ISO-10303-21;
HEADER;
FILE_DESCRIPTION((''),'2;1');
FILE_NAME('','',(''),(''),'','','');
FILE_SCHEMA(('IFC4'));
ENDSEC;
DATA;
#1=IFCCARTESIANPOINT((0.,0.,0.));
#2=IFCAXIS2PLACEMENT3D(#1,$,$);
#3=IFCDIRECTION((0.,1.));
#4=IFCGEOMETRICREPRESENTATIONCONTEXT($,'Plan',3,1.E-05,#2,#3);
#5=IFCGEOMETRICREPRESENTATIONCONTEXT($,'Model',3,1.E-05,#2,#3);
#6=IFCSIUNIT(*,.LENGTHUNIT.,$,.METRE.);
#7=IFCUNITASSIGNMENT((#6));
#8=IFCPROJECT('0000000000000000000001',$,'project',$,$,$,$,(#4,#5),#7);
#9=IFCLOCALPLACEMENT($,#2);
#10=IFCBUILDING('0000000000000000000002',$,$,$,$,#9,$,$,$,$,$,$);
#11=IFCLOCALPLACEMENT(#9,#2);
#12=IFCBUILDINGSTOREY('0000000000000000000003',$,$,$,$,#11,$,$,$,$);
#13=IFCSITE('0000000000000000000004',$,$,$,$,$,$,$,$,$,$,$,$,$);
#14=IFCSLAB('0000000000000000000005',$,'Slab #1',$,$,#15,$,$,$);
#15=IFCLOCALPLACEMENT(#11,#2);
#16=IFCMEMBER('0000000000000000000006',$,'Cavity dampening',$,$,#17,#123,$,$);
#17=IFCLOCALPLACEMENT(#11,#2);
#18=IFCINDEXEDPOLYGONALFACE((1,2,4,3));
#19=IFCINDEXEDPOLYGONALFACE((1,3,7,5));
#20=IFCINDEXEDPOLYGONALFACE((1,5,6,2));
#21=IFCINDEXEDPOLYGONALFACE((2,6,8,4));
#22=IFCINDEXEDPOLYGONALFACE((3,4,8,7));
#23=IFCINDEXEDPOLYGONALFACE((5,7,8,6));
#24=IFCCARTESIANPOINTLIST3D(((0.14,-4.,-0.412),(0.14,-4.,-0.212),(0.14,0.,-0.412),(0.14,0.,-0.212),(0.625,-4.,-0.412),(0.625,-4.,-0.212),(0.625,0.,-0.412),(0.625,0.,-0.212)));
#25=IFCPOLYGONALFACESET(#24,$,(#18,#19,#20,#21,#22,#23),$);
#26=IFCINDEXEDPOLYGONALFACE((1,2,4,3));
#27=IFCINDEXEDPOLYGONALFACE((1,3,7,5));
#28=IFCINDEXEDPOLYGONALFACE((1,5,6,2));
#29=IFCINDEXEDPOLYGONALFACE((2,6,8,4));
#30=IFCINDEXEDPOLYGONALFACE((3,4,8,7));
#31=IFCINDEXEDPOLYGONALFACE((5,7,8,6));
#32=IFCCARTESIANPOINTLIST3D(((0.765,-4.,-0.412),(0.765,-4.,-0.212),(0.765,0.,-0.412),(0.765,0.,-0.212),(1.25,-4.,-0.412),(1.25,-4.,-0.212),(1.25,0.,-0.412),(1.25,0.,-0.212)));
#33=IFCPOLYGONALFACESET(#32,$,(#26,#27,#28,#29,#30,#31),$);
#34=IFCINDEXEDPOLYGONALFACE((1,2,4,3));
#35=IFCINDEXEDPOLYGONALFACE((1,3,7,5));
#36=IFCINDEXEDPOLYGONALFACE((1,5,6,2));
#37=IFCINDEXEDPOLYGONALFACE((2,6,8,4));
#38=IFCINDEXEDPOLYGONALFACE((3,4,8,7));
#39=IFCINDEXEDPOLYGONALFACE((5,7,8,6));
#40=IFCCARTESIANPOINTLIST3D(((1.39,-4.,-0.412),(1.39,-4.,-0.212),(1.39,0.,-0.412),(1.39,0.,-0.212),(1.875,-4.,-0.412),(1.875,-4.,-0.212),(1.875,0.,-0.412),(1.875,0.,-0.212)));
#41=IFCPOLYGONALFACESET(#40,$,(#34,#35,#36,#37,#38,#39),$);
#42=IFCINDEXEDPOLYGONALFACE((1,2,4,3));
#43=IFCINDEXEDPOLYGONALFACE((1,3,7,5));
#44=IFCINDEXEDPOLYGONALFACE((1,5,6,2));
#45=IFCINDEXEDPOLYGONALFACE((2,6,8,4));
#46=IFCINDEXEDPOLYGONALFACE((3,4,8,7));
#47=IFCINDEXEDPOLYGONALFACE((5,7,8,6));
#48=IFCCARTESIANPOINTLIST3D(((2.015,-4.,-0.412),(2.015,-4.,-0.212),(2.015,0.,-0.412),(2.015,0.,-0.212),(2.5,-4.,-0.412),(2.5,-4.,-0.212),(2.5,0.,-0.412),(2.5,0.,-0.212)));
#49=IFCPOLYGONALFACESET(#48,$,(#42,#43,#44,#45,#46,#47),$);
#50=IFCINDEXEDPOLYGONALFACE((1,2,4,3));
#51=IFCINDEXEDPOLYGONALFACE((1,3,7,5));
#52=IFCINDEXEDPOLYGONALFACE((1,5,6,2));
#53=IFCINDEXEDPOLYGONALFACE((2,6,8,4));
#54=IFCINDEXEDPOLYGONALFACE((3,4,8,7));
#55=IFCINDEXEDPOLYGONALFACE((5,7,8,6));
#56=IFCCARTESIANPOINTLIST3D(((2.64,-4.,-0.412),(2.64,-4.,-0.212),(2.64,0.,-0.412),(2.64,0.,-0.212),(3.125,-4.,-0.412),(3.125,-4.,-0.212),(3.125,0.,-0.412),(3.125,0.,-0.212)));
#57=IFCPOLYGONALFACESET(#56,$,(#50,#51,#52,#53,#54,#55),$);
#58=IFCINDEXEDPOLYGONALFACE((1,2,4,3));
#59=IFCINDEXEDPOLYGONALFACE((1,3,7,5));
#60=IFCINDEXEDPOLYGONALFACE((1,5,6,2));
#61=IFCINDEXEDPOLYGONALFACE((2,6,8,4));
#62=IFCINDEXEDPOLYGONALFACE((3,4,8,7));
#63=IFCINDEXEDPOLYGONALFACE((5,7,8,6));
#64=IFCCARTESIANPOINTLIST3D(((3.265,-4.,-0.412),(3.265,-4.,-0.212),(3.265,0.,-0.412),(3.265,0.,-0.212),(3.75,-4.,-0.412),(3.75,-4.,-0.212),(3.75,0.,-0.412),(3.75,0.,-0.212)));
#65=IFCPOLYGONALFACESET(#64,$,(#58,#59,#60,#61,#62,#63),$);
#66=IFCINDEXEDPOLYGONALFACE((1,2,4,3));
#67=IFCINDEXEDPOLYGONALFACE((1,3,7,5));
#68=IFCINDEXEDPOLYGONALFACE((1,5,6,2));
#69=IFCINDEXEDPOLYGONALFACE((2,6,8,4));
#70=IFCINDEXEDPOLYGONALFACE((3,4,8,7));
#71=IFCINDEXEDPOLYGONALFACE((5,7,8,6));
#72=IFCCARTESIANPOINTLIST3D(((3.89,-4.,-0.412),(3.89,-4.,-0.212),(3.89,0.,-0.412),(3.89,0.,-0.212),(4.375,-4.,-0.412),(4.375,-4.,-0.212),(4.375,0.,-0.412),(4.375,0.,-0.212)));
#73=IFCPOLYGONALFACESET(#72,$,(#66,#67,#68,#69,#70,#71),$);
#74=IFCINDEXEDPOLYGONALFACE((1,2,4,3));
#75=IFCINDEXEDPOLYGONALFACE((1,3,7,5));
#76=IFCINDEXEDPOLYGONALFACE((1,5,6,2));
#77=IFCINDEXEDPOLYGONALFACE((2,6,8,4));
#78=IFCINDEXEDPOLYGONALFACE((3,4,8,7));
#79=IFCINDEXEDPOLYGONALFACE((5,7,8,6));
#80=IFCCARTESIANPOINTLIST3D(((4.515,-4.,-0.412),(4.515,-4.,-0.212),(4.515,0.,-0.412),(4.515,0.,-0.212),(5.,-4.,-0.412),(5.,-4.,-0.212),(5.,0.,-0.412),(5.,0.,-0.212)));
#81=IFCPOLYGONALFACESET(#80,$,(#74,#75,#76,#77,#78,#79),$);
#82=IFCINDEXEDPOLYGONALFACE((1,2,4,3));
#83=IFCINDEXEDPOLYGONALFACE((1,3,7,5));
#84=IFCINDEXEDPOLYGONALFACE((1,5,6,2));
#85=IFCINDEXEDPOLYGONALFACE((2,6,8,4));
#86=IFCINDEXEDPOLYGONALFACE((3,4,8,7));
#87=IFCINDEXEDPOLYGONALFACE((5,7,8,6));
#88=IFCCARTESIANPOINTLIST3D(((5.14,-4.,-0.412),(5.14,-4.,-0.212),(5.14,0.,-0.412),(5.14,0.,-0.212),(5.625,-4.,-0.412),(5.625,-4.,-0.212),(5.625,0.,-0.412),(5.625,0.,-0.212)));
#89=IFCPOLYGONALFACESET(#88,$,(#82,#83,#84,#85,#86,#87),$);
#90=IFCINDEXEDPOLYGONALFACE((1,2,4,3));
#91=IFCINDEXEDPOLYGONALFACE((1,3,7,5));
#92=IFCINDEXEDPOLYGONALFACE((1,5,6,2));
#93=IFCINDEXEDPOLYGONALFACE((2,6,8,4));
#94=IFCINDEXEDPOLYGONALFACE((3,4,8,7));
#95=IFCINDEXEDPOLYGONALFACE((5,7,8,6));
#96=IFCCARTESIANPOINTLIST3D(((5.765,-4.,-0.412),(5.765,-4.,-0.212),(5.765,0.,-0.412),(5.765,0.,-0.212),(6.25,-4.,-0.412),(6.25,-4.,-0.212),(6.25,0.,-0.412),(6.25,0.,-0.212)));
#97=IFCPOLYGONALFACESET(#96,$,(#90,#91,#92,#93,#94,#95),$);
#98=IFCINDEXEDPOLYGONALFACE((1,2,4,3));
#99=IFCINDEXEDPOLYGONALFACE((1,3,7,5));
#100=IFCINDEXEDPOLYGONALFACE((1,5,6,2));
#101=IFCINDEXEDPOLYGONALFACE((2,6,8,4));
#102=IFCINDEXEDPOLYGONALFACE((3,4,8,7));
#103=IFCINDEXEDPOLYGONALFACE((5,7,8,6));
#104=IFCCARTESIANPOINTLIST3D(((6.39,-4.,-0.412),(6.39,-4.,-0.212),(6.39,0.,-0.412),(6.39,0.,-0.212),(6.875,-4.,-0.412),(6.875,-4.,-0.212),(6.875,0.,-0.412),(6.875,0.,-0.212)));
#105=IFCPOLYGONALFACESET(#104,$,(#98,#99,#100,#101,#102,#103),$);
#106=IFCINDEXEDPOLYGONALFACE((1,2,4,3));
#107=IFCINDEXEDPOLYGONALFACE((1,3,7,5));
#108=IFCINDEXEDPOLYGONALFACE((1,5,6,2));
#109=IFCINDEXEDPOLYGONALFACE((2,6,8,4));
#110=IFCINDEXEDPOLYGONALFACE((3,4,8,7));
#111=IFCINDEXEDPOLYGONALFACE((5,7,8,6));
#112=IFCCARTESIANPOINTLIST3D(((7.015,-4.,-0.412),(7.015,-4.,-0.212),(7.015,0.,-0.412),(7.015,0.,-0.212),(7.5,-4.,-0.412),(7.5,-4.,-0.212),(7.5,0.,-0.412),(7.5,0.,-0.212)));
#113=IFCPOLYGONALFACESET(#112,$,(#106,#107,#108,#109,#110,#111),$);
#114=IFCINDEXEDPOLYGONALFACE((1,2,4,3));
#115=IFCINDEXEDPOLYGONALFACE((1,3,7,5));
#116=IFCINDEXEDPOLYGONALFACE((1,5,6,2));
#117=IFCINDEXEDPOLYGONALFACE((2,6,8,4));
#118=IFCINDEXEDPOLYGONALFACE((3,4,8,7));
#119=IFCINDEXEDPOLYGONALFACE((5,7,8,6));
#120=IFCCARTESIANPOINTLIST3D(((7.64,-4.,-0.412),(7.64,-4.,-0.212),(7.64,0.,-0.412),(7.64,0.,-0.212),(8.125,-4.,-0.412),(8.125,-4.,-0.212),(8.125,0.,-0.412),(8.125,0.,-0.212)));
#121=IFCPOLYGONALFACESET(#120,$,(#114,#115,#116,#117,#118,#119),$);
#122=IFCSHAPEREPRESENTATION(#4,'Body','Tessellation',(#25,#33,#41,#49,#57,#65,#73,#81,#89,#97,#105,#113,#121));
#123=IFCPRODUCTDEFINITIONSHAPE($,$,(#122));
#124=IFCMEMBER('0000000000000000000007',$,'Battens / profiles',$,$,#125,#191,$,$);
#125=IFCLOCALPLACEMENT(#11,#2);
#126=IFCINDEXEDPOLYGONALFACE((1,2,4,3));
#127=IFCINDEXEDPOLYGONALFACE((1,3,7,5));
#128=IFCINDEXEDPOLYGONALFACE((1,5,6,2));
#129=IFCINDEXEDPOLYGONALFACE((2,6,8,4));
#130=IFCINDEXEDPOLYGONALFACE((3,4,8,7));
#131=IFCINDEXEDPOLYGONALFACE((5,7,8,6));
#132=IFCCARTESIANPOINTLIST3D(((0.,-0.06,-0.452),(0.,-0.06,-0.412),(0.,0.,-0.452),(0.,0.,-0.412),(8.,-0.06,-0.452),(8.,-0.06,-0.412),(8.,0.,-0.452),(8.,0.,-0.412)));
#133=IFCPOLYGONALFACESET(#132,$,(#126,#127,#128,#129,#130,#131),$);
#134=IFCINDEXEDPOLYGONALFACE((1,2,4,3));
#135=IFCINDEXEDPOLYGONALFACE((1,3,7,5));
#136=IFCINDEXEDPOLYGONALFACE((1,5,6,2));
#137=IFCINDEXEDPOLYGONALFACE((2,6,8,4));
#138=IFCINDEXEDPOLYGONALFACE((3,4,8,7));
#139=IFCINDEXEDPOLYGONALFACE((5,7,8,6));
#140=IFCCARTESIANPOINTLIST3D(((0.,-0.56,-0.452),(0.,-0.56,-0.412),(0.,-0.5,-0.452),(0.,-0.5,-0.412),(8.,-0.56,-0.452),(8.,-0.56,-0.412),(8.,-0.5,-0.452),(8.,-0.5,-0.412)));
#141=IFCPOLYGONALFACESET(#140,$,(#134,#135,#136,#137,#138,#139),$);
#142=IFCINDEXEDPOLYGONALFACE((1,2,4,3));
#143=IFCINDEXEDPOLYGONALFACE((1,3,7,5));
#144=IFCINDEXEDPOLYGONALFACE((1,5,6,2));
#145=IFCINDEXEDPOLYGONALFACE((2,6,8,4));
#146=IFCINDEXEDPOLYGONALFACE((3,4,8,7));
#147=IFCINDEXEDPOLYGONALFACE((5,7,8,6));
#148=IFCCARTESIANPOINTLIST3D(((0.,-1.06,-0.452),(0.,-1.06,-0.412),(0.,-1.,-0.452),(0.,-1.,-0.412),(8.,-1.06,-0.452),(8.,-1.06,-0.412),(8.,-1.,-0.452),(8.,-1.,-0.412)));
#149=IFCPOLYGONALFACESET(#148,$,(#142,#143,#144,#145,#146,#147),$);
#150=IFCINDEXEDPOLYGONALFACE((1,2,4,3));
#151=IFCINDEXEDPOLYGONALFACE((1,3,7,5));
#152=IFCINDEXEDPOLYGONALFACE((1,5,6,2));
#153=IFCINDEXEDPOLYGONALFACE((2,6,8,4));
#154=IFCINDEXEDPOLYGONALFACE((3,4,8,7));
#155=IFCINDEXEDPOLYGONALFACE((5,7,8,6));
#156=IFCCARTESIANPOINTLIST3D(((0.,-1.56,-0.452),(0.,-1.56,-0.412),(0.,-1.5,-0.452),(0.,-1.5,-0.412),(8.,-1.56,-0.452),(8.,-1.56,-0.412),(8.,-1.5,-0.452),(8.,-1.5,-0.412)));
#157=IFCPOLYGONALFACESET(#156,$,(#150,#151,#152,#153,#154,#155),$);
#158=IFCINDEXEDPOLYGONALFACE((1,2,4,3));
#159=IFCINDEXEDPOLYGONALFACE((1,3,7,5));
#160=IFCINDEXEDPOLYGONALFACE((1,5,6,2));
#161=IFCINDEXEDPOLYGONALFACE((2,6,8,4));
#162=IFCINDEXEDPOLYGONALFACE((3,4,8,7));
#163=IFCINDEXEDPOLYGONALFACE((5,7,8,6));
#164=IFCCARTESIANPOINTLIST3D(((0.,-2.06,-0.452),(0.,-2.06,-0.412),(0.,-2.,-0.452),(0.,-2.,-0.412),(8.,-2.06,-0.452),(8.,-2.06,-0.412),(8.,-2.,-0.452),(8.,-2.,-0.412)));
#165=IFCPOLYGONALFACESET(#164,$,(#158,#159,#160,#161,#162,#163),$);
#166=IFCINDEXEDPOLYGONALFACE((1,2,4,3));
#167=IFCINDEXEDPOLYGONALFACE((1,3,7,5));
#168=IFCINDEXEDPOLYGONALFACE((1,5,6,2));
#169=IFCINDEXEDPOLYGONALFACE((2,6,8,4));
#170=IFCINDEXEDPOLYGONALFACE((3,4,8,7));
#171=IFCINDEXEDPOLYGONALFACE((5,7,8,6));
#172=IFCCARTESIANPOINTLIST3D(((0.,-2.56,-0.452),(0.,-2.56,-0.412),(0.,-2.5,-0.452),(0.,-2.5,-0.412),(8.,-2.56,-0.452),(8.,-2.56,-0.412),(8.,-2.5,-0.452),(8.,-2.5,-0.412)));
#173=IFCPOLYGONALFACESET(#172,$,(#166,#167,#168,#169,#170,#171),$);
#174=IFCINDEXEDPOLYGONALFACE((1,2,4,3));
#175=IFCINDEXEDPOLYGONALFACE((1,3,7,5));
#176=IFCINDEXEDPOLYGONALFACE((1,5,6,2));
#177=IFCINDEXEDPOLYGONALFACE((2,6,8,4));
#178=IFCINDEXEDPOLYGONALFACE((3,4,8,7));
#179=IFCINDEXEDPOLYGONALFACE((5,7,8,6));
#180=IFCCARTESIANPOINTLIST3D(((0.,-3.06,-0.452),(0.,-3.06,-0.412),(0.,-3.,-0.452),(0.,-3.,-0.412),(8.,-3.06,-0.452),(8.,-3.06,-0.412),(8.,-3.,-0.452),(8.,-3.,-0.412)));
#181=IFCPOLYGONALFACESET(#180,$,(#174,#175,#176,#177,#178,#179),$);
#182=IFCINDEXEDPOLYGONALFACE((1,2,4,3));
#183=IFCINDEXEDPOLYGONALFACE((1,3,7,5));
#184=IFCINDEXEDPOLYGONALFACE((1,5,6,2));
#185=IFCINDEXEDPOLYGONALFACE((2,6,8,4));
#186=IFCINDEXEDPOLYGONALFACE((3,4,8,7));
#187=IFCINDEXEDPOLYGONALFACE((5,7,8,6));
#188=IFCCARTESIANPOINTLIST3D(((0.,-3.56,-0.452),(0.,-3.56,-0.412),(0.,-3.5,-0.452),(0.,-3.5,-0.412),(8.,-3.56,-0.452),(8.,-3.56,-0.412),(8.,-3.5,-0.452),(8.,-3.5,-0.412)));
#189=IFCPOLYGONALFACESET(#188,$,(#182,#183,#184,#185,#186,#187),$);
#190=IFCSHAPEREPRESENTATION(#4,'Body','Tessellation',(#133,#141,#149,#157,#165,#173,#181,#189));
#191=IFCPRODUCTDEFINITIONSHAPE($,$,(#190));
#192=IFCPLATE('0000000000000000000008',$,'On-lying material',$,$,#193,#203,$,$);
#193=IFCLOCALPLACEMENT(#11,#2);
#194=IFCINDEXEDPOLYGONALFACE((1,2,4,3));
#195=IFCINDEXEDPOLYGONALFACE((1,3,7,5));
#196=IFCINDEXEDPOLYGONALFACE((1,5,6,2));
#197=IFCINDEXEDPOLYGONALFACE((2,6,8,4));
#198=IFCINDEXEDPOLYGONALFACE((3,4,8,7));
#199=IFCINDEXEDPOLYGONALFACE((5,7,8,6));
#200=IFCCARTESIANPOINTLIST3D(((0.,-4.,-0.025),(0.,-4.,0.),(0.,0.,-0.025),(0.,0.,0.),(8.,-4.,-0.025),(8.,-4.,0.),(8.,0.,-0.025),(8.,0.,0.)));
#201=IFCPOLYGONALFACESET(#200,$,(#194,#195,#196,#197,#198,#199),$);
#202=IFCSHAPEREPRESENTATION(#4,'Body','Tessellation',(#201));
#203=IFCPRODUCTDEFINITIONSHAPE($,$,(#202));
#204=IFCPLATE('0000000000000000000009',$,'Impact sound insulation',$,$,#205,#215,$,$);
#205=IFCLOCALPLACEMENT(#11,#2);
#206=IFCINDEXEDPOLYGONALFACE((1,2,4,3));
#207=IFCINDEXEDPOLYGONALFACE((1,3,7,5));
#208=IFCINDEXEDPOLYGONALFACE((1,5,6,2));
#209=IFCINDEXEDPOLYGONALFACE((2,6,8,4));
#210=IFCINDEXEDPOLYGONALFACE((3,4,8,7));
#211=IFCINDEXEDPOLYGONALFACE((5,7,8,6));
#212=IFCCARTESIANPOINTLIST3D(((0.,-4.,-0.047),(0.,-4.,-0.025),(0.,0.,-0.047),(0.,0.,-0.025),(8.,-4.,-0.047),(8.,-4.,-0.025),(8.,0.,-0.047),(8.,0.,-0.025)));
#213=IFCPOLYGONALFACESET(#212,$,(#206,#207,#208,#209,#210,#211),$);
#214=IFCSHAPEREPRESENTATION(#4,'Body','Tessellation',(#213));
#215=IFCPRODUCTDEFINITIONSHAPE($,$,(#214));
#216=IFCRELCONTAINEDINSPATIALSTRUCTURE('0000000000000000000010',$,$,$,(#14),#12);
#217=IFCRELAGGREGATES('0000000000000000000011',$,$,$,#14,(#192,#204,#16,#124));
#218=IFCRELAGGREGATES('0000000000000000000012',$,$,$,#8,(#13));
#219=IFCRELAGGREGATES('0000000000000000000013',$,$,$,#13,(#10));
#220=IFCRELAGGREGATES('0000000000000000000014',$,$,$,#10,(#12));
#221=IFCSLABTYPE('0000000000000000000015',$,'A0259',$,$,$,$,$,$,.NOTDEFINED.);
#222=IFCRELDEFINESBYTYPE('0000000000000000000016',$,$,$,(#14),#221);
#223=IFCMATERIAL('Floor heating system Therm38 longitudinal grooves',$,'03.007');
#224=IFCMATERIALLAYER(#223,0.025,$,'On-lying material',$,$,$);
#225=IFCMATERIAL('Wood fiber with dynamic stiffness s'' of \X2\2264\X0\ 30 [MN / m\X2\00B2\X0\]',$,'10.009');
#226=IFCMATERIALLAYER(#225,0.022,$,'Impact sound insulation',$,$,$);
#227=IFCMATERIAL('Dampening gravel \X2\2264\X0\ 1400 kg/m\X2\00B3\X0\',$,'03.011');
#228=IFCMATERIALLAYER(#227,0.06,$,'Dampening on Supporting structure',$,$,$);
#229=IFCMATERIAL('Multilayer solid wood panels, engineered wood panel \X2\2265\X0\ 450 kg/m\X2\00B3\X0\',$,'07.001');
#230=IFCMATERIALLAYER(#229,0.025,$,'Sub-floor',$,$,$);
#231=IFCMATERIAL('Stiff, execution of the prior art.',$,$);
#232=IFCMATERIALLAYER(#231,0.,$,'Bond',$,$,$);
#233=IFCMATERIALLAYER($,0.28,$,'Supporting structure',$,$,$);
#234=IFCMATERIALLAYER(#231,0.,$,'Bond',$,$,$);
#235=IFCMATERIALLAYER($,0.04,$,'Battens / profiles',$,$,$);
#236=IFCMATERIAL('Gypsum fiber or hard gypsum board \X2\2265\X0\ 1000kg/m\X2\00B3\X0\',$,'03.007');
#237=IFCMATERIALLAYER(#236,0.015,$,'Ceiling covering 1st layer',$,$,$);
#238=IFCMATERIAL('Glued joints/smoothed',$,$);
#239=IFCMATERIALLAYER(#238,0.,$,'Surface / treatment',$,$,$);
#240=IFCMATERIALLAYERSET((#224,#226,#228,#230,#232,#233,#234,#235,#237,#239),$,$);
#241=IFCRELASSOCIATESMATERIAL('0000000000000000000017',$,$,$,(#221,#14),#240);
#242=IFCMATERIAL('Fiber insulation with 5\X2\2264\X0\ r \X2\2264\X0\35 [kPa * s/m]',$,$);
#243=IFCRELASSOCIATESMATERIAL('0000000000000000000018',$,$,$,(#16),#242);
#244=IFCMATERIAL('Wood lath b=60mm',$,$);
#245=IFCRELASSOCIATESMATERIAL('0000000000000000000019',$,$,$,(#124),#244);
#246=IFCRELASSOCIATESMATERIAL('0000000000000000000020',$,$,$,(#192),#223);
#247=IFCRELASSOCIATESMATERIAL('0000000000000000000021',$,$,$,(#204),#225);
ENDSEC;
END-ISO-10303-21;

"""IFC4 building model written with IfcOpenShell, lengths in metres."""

from ifc_helpers import new_model, si_unit, direction, frame, frame_2d, origin, origin_with_axes, place, context, project, spatial, rectangle, extrude, material, layer, layer_set, type_object, element, aggregate, save


model = new_model("IFC4")

# Units and contexts
plan_context = context("Plan", 3, precision=1e-05, world=origin(), true_north=direction((0.0, 1.0)))
model_context = context("Model", 3, precision=1e-05, world=origin(), true_north=direction((0.0, 1.0)))
ifc_project = project(units=[si_unit("LENGTHUNIT", "METRE")], contexts=[plan_context, model_context])

# Site, building, storey
site = spatial("IfcSite", under=ifc_project)
building_placement = place(None, origin())
building = spatial("IfcBuilding", under=site, at=building_placement)
storey_placement = place(building_placement, origin())
storey = spatial("IfcBuildingStorey", under=building, at=storey_placement)

# Slab, members, plates
ifc_material_1 = material(Name="Floor heating system Therm38 longitudinal grooves", Category="03.007")
ifc_layer_1 = layer(ifc_material_1, 0.025, Name="On-lying material")
ifc_material_2 = material(Name="Wood fiber with dynamic stiffness s' of ≤ 30 [MN / m²]", Category="10.009")
ifc_layer_2 = layer(ifc_material_2, 0.022, Name="Impact sound insulation")
ifc_material_3 = material(Name="Dampening gravel ≤ 1400 kg/m³", Category="03.011")
ifc_layer_3 = layer(ifc_material_3, 0.06, Name="Dampening on Supporting structure")
ifc_material_4 = material(Name="Multilayer solid wood panels, engineered wood panel ≥ 450 kg/m³", Category="07.001")
ifc_layer_4 = layer(ifc_material_4, 0.025, Name="Sub-floor")
ifc_material_5 = material(Name="Stiff, execution of the prior art.")
ifc_layer_5 = layer(ifc_material_5, 0.0, Name="Bond")
ifc_layer_6 = layer(None, 0.28, Name="Supporting structure")
ifc_layer_7 = layer(ifc_material_5, 0.0, Name="Bond")
ifc_layer_8 = layer(None, 0.04, Name="Battens / profiles")
ifc_material_6 = material(Name="Gypsum fiber or hard gypsum board ≥ 1000kg/m³", Category="03.007")
ifc_layer_9 = layer(ifc_material_6, 0.015, Name="Ceiling covering 1st layer")
ifc_material_7 = material(Name="Glued joints/smoothed")
ifc_layer_10 = layer(ifc_material_7, 0.0, Name="Surface / treatment")
ifc_layer_set = layer_set([ifc_layer_1, ifc_layer_2, ifc_layer_3, ifc_layer_4, ifc_layer_5, ifc_layer_6, ifc_layer_7, ifc_layer_8, ifc_layer_9, ifc_layer_10])
slab_type = type_object("IfcSlabType", Name="A0259", PredefinedType="NOTDEFINED", material=ifc_layer_set)
slab_placement = place(None, frame((0.0, 0.0, 0.0), z_axis=(0.0, 0.0, -1.0), x_axis=(1.0, 0.0, 0.0)))
slab = element("IfcSlab", 1, at=slab_placement, inside=storey, type_object=slab_type, material=ifc_layer_set, Name="Slab #1")
ifc_material_8 = material(Name="Fiber insulation with 5≤ r ≤35 [kPa * s/m]")
member_1_placement = place(slab_placement, origin())
member_1 = element("IfcMember", 2, at=member_1_placement, material=ifc_material_8, Name="Cavity dampening", context=plan_context, shape_type="SweptSolid", body=[
    extrude(rectangle(XDim=0.485, YDim=0.2, at=frame_2d((0.2425, 0.1), x_axis=(1.0, 0.0))), frame((0.14, 4.0, 0.212), z_axis=(0.0, -1.0, 0.0), x_axis=(1.0, 0.0, 0.0)), (0.0, 0.0, 1.0), 4.0),
    extrude(rectangle(XDim=0.485, YDim=0.2, at=frame_2d((0.2425, 0.1), x_axis=(1.0, 0.0))), frame((0.765, 4.0, 0.212), z_axis=(0.0, -1.0, 0.0), x_axis=(1.0, 0.0, 0.0)), (0.0, 0.0, 1.0), 4.0),
    extrude(rectangle(XDim=0.485, YDim=0.2, at=frame_2d((0.2425, 0.1), x_axis=(1.0, 0.0))), frame((1.39, 4.0, 0.212), z_axis=(0.0, -1.0, 0.0), x_axis=(1.0, 0.0, 0.0)), (0.0, 0.0, 1.0), 4.0),
    extrude(rectangle(XDim=0.485, YDim=0.2, at=frame_2d((0.2425, 0.1), x_axis=(1.0, 0.0))), frame((2.015, 4.0, 0.212), z_axis=(0.0, -1.0, 0.0), x_axis=(1.0, 0.0, 0.0)), (0.0, 0.0, 1.0), 4.0),
    extrude(rectangle(XDim=0.485, YDim=0.2, at=frame_2d((0.2425, 0.1), x_axis=(1.0, 0.0))), frame((2.64, 4.0, 0.212), z_axis=(0.0, -1.0, 0.0), x_axis=(1.0, 0.0, 0.0)), (0.0, 0.0, 1.0), 4.0),
    extrude(rectangle(XDim=0.485, YDim=0.2, at=frame_2d((0.2425, 0.1), x_axis=(1.0, 0.0))), frame((3.265, 4.0, 0.212), z_axis=(0.0, -1.0, 0.0), x_axis=(1.0, 0.0, 0.0)), (0.0, 0.0, 1.0), 4.0),
    extrude(rectangle(XDim=0.485, YDim=0.2, at=frame_2d((0.2425, 0.1), x_axis=(1.0, 0.0))), frame((3.89, 4.0, 0.212), z_axis=(0.0, -1.0, 0.0), x_axis=(1.0, 0.0, 0.0)), (0.0, 0.0, 1.0), 4.0),
    extrude(rectangle(XDim=0.485, YDim=0.2, at=frame_2d((0.2425, 0.1), x_axis=(1.0, 0.0))), frame((4.515, 4.0, 0.212), z_axis=(0.0, -1.0, 0.0), x_axis=(1.0, 0.0, 0.0)), (0.0, 0.0, 1.0), 4.0),
    extrude(rectangle(XDim=0.485, YDim=0.2, at=frame_2d((0.2425, 0.1), x_axis=(1.0, 0.0))), frame((5.14, 4.0, 0.212), z_axis=(0.0, -1.0, 0.0), x_axis=(1.0, 0.0, 0.0)), (0.0, 0.0, 1.0), 4.0),
    extrude(rectangle(XDim=0.485, YDim=0.2, at=frame_2d((0.2425, 0.1), x_axis=(1.0, 0.0))), frame((5.765, 4.0, 0.212), z_axis=(0.0, -1.0, 0.0), x_axis=(1.0, 0.0, 0.0)), (0.0, 0.0, 1.0), 4.0),
    extrude(rectangle(XDim=0.485, YDim=0.2, at=frame_2d((0.2425, 0.1), x_axis=(1.0, 0.0))), frame((6.39, 4.0, 0.212), z_axis=(0.0, -1.0, 0.0), x_axis=(1.0, 0.0, 0.0)), (0.0, 0.0, 1.0), 4.0),
    extrude(rectangle(XDim=0.485, YDim=0.2, at=frame_2d((0.2425, 0.1), x_axis=(1.0, 0.0))), frame((7.015, 4.0, 0.212), z_axis=(0.0, -1.0, 0.0), x_axis=(1.0, 0.0, 0.0)), (0.0, 0.0, 1.0), 4.0),
    extrude(rectangle(XDim=0.485, YDim=0.2, at=frame_2d((0.2425, 0.1), x_axis=(1.0, 0.0))), frame((7.64, 4.0, 0.212), z_axis=(0.0, -1.0, 0.0), x_axis=(1.0, 0.0, 0.0)), (0.0, 0.0, 1.0), 4.0),
])
ifc_material_9 = material(Name="Wood lath b=60mm")
member_2_placement = place(slab_placement, origin())
member_2 = element("IfcMember", 3, at=member_2_placement, material=ifc_material_9, Name="Battens / profiles", context=plan_context, shape_type="SweptSolid", body=[
    extrude(rectangle(XDim=0.06, YDim=0.04, at=frame_2d((0.03, 0.02), x_axis=(1.0, 0.0))), frame((0.0, 0.0, 0.412), z_axis=(1.0, 0.0, 0.0), x_axis=(0.0, 1.0, 0.0)), (0.0, 0.0, 1.0), 8.0),
    extrude(rectangle(XDim=0.06, YDim=0.04, at=frame_2d((0.03, 0.02), x_axis=(1.0, 0.0))), frame((0.0, 0.5, 0.412), z_axis=(1.0, 0.0, 0.0), x_axis=(0.0, 1.0, 0.0)), (0.0, 0.0, 1.0), 8.0),
    extrude(rectangle(XDim=0.06, YDim=0.04, at=frame_2d((0.03, 0.02), x_axis=(1.0, 0.0))), frame((0.0, 1.0, 0.412), z_axis=(1.0, 0.0, 0.0), x_axis=(0.0, 1.0, 0.0)), (0.0, 0.0, 1.0), 8.0),
    extrude(rectangle(XDim=0.06, YDim=0.04, at=frame_2d((0.03, 0.02), x_axis=(1.0, 0.0))), frame((0.0, 1.5, 0.412), z_axis=(1.0, 0.0, 0.0), x_axis=(0.0, 1.0, 0.0)), (0.0, 0.0, 1.0), 8.0),
    extrude(rectangle(XDim=0.06, YDim=0.04, at=frame_2d((0.03, 0.02), x_axis=(1.0, 0.0))), frame((0.0, 2.0, 0.412), z_axis=(1.0, 0.0, 0.0), x_axis=(0.0, 1.0, 0.0)), (0.0, 0.0, 1.0), 8.0),
    extrude(rectangle(XDim=0.06, YDim=0.04, at=frame_2d((0.03, 0.02), x_axis=(1.0, 0.0))), frame((0.0, 2.5, 0.412), z_axis=(1.0, 0.0, 0.0), x_axis=(0.0, 1.0, 0.0)), (0.0, 0.0, 1.0), 8.0),
    extrude(rectangle(XDim=0.06, YDim=0.04, at=frame_2d((0.03, 0.02), x_axis=(1.0, 0.0))), frame((0.0, 3.0, 0.412), z_axis=(1.0, 0.0, 0.0), x_axis=(0.0, 1.0, 0.0)), (0.0, 0.0, 1.0), 8.0),
    extrude(rectangle(XDim=0.06, YDim=0.04, at=frame_2d((0.03, 0.02), x_axis=(1.0, 0.0))), frame((0.0, 3.5, 0.412), z_axis=(1.0, 0.0, 0.0), x_axis=(0.0, 1.0, 0.0)), (0.0, 0.0, 1.0), 8.0),
])
plate_1_placement = place(slab_placement, origin())
plate_1 = element("IfcPlate", 4, at=plate_1_placement, material=ifc_material_1, Name="On-lying material", context=plan_context, shape_type="SweptSolid", body=[
    extrude(rectangle(XDim=8.0, YDim=4.0, at=frame_2d((4.0, 2.0), x_axis=(1.0, 0.0))), origin_with_axes(), (0.0, 0.0, 1.0), 0.025),
])
plate_2_placement = place(slab_placement, origin())
plate_2 = element("IfcPlate", 5, at=plate_2_placement, material=ifc_material_2, Name="Impact sound insulation", context=plan_context, shape_type="SweptSolid", body=[
    extrude(rectangle(XDim=8.0, YDim=4.0, at=frame_2d((4.0, 2.0), x_axis=(1.0, 0.0))), frame((0.0, 0.0, 0.025), z_axis=(0.0, 0.0, 1.0), x_axis=(1.0, 0.0, 0.0)), (0.0, 0.0, 1.0), 0.022),
])
aggregate(slab, [plate_1, plate_2, member_1, member_2])

save(model, "model.ifc")
